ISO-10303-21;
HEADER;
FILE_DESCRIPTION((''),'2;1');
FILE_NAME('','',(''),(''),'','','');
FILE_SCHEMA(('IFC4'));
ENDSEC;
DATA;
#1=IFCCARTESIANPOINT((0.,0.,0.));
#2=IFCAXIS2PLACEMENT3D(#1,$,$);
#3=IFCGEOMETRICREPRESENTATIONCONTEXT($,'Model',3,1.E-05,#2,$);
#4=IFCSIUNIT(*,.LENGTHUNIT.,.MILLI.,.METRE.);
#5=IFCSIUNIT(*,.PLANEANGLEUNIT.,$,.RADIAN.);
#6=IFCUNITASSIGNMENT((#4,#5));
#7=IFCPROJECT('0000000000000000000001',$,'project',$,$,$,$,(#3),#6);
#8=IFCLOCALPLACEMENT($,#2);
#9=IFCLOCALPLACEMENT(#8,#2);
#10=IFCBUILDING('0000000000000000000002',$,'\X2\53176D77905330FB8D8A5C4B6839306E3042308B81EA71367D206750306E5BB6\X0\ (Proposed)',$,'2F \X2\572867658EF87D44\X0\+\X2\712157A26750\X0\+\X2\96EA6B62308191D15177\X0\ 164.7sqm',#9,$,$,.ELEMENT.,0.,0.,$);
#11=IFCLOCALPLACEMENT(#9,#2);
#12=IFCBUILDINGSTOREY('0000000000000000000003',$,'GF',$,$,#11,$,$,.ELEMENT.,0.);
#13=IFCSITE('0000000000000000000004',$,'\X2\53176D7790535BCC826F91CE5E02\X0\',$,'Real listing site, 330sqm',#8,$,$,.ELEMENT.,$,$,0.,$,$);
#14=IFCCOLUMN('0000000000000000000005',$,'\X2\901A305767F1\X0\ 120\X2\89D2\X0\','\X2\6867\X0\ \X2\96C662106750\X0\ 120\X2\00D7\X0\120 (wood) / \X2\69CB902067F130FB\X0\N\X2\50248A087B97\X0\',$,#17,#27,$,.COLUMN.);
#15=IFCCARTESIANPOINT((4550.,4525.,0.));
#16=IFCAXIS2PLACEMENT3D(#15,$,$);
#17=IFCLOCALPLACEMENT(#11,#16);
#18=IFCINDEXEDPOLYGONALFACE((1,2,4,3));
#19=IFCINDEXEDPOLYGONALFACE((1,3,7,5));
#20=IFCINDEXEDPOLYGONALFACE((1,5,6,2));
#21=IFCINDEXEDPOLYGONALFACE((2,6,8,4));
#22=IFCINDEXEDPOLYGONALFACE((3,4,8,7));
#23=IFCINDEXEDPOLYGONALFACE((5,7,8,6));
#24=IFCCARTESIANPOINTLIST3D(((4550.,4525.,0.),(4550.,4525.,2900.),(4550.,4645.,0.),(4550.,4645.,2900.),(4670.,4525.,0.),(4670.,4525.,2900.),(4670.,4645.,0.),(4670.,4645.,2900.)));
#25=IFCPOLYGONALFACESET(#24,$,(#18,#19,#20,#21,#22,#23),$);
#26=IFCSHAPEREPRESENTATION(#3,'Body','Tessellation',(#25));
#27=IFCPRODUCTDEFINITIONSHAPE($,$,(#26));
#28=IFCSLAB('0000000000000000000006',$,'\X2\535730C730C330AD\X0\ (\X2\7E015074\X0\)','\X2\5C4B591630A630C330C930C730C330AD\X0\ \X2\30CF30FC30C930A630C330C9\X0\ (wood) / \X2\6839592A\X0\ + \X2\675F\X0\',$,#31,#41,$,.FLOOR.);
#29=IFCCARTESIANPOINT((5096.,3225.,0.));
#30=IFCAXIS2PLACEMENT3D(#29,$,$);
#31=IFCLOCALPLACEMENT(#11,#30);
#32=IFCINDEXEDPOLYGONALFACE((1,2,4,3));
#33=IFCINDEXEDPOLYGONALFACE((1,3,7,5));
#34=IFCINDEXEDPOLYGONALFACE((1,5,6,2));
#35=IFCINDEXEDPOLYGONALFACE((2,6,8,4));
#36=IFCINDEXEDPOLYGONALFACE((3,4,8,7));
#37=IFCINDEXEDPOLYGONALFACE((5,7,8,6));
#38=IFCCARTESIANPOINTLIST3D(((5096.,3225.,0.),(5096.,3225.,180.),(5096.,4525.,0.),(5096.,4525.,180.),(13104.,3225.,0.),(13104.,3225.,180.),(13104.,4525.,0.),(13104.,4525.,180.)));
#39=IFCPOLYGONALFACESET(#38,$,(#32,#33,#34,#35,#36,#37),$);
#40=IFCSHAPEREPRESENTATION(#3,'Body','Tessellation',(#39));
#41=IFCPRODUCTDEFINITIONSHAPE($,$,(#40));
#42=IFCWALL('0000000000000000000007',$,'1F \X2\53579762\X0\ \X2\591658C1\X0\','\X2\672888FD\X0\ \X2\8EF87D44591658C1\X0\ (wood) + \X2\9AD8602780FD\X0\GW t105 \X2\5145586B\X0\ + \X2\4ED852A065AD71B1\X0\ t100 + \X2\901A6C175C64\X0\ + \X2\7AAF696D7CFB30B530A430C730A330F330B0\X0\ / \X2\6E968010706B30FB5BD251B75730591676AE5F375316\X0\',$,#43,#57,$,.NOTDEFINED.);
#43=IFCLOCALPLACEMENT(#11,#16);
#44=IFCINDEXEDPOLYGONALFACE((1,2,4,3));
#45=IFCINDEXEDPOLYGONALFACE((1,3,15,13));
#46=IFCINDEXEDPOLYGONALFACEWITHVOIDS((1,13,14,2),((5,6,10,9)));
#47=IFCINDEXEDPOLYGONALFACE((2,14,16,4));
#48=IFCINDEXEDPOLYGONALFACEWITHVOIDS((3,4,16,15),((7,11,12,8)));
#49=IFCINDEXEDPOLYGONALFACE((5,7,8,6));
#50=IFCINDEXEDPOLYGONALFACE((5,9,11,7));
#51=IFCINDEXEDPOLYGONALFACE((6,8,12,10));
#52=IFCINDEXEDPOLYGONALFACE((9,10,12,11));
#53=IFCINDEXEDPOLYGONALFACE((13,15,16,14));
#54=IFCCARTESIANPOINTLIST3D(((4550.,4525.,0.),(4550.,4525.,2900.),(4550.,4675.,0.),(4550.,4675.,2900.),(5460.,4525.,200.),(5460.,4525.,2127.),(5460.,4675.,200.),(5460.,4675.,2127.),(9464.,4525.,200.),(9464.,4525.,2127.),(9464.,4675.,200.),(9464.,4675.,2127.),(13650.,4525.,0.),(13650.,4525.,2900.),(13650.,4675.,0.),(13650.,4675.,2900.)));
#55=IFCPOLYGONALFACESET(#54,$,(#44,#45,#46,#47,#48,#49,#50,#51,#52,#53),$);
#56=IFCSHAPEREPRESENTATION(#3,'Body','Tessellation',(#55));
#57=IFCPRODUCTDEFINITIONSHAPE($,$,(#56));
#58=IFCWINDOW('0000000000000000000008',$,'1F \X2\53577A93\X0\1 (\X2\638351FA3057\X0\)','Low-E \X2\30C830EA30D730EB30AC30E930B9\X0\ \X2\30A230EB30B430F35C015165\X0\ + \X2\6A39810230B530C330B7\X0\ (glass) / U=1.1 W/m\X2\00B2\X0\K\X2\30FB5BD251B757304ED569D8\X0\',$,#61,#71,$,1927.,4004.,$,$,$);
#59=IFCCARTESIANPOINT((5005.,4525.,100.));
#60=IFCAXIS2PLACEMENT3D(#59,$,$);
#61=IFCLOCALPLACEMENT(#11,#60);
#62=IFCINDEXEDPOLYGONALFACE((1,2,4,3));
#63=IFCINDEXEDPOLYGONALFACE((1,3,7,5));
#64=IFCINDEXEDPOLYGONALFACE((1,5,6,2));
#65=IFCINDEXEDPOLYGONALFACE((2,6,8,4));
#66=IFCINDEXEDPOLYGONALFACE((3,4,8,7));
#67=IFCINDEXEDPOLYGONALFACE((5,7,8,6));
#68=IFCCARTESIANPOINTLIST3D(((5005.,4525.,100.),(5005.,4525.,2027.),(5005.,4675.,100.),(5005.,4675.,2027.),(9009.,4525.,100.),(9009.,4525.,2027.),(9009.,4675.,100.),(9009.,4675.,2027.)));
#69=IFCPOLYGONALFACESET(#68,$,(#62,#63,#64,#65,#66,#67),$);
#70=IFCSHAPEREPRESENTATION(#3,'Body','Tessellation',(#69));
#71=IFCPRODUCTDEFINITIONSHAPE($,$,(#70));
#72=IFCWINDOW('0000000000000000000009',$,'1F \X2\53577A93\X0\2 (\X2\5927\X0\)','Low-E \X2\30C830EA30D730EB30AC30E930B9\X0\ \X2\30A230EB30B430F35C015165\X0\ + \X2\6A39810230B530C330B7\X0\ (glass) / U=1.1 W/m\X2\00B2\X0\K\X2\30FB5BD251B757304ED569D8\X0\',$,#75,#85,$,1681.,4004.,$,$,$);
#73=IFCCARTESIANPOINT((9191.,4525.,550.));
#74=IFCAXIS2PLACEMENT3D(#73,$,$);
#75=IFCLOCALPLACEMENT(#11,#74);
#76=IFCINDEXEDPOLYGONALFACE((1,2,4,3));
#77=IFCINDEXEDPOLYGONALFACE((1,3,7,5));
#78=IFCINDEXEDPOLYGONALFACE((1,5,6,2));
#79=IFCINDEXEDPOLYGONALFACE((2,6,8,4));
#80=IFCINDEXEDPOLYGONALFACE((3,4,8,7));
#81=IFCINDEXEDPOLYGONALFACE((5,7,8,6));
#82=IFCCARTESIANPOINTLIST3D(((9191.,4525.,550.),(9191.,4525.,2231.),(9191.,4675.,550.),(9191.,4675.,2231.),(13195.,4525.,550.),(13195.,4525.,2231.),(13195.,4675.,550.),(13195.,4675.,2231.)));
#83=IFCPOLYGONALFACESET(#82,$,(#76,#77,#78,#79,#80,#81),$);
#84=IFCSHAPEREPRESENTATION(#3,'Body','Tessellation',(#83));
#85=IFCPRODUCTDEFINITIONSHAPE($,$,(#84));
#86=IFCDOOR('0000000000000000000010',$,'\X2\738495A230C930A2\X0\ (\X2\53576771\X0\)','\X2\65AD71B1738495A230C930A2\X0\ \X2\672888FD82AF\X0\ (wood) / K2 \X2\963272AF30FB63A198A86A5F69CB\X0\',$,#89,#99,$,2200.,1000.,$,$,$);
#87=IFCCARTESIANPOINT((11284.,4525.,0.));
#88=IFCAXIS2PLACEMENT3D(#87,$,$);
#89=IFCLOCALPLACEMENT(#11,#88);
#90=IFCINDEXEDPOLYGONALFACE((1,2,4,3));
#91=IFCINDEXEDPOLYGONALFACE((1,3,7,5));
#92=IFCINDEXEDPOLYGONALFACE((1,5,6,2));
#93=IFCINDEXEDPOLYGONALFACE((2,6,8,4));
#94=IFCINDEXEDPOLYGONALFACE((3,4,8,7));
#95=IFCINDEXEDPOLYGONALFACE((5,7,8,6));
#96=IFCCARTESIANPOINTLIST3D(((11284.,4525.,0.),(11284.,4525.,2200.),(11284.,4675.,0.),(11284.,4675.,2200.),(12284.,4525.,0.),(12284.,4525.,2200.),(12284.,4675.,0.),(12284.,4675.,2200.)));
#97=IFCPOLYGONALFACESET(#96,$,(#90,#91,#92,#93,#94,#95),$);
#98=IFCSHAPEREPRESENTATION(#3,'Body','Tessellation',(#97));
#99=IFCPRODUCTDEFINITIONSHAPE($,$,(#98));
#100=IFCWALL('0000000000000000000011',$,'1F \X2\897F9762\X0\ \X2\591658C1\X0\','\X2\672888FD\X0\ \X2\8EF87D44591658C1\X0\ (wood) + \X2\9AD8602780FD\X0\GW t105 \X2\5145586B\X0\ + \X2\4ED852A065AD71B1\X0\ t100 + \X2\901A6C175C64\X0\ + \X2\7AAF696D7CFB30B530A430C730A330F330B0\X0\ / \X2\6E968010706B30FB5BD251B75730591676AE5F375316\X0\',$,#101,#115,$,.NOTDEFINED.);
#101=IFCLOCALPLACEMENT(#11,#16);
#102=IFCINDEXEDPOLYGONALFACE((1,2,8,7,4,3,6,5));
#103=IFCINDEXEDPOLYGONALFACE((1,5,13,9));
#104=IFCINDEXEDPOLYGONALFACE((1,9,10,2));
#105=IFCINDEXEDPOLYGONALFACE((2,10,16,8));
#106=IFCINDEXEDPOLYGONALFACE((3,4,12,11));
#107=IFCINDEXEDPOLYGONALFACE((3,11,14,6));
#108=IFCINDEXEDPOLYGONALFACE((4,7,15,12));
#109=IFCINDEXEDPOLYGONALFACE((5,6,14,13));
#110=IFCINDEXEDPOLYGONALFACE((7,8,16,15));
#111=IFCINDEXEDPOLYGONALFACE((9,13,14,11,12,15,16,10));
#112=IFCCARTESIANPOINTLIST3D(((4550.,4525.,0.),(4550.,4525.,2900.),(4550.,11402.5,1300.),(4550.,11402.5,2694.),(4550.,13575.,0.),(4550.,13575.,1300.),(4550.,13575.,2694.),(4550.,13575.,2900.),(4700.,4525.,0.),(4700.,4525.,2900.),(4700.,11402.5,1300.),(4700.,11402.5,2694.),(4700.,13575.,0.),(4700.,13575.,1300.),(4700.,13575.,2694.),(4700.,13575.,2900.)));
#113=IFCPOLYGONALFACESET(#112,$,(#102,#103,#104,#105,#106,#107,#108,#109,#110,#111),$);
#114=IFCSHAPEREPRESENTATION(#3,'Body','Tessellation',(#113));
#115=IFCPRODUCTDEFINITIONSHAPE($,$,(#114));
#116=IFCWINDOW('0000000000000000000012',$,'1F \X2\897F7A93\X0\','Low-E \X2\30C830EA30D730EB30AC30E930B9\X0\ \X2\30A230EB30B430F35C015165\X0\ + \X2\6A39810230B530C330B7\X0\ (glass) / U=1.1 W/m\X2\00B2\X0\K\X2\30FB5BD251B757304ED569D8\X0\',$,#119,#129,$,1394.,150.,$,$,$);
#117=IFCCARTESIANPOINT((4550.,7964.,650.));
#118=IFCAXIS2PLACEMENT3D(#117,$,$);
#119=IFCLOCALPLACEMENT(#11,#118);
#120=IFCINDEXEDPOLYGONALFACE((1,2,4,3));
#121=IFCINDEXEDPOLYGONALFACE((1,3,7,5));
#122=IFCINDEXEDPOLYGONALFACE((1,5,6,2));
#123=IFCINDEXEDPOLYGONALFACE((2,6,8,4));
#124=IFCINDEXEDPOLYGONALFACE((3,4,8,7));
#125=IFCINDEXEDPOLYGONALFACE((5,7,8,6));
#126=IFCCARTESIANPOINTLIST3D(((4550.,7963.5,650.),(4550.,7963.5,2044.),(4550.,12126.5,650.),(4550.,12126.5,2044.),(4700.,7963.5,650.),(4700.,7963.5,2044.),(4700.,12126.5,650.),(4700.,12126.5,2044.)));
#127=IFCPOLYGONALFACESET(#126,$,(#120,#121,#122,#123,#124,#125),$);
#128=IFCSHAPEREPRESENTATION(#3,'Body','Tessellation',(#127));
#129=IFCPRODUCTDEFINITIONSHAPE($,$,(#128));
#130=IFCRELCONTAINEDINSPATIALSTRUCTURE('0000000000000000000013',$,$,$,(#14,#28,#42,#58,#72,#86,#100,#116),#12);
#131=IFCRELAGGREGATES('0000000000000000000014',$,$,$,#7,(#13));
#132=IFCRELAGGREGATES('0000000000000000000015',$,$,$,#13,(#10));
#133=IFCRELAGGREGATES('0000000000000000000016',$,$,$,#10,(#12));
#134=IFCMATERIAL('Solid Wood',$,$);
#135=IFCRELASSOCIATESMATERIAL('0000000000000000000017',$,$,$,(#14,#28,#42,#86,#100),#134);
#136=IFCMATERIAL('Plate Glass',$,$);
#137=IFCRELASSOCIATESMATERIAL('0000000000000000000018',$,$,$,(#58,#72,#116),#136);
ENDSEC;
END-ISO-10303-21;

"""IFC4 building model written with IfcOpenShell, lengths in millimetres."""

from ifc_helpers import new_model, si_unit, frame, frame_2d, origin, place, context, project, spatial, rectangle, extrude, material, element, fill, save


model = new_model("IFC4")

# Units and contexts
model_context = context("Model", 3, precision=1e-05, world=origin())
ifc_project = project(units=[si_unit("LENGTHUNIT", "METRE", prefix="MILLI"), si_unit("PLANEANGLEUNIT", "RADIAN")], contexts=[model_context])

# Site, building, storey
site_placement = place(None, origin())
site = spatial("IfcSite", under=ifc_project, at=site_placement, Name="北海道富良野市", ObjectType="Real listing site, 330sqm", CompositionType="ELEMENT", RefElevation=0.0)
building_placement = place(site_placement, origin())
building = spatial("IfcBuilding", under=site, at=building_placement, Name="北海道・越屋根のある自然素材の家 (Proposed)", ObjectType="2F 在来軸組+無垢材+雪止め金具 164.7sqm", CompositionType="ELEMENT", ElevationOfRefHeight=0.0, ElevationOfTerrain=0.0)
storey_placement = place(building_placement, origin())
storey = spatial("IfcBuildingStorey", under=building, at=storey_placement, Name="GF", CompositionType="ELEMENT", Elevation=0.0)

# Column
ifc_material_1 = material(Name="Solid Wood")
column_placement = place(storey_placement, frame((4550.0, 4525.0, 0.0)))
element("IfcColumn", 1, at=column_placement, inside=storey, material=ifc_material_1, Name="通し柱 120角", Description="桧 集成材 120×120 (wood) / 構造柱・N値計算", PredefinedType="COLUMN", context=model_context, shape_type="SweptSolid", body=[
    extrude(rectangle(XDim=120.0, YDim=120.0, at=frame_2d((60.0, 60.0))), frame((4550.0, 4525.0, 0.0)), (0.0, 0.0, 1.0), 2900.0),
])

# Slab
slab_1_placement = place(storey_placement, frame((5096.0, 3225.0, 0.0)))
element("IfcSlab", 2, at=slab_1_placement, inside=storey, material=ifc_material_1, Name="南デッキ (縁側)", Description="屋外ウッドデッキ ハードウッド (wood) / 根太 + 束", PredefinedType="FLOOR", context=model_context, shape_type="SweptSolid", body=[
    extrude(rectangle(XDim=8008.0, YDim=1300.0, at=frame_2d((4004.0, 650.0))), frame((5096.0, 3225.0, 0.0)), (0.0, 0.0, 1.0), 180.0),
])

# Wall, openings, windows, door
wall_1_placement = place(storey_placement, frame((4550.0, 4525.0, 0.0)))
wall_1 = element("IfcWall", 3, at=wall_1_placement, inside=storey, material=ifc_material_1, Name="1F 南面 外壁", Description="木製 軸組外壁 (wood) + 高性能GW t105 充填 + 付加断熱 t100 + 通気層 + 窯業系サイディング / 準耐火・寒冷地外皮強化", PredefinedType="NOTDEFINED", context=model_context, shape_type="SweptSolid", body=[
    extrude(rectangle(XDim=9100.0, YDim=150.0, at=frame_2d((4550.0, 75.0))), frame((4550.0, 4525.0, 0.0)), (0.0, 0.0, 1.0), 2900.0),
])
opening_1_placement = place(storey_placement, frame((5005.0, 4525.0, 100.0)))
opening_1 = element("IfcOpeningElement", 4, at=opening_1_placement, cuts=wall_1, PredefinedType="NOTDEFINED", context=model_context, shape_type="SweptSolid", body=[
    extrude(rectangle(XDim=4004.0, YDim=150.0, at=frame_2d((2002.0, 75.0))), frame((5005.0, 4525.0, 100.0)), (0.0, 0.0, 1.0), 1927.0),
])
opening_2_placement = place(storey_placement, frame((9191.0, 4525.0, 550.0)))
opening_2 = element("IfcOpeningElement", 5, at=opening_2_placement, cuts=wall_1, PredefinedType="NOTDEFINED", context=model_context, shape_type="SweptSolid", body=[
    extrude(rectangle(XDim=4004.0, YDim=150.0, at=frame_2d((2002.0, 75.0))), frame((9191.0, 4525.0, 550.0)), (0.0, 0.0, 1.0), 1681.0),
])
opening_3_placement = place(storey_placement, frame((11284.0, 4525.0, 0.0)))
opening_3 = element("IfcOpeningElement", 6, at=opening_3_placement, cuts=wall_1, PredefinedType="NOTDEFINED", context=model_context, shape_type="SweptSolid", body=[
    extrude(rectangle(XDim=1000.0, YDim=150.0, at=frame_2d((500.0, 75.0))), frame((11284.0, 4525.0, 0.0)), (0.0, 0.0, 1.0), 2200.0),
])
ifc_material_2 = material(Name="Plate Glass")
window_1_placement = place(storey_placement, frame((5005.0, 4525.0, 100.0)))
window_1 = element("IfcWindow", 7, at=window_1_placement, inside=storey, material=ifc_material_2, Name="1F 南窓1 (掃出し)", Description="Low-E トリプルガラス アルゴン封入 + 樹脂サッシ (glass) / U=1.1 W/m²K・寒冷地仕様", OverallHeight=1927.0, OverallWidth=4004.0, context=model_context, shape_type="SweptSolid", body=[
    extrude(rectangle(XDim=4004.0, YDim=150.0, at=frame_2d((2002.0, 75.0))), frame((5005.0, 4525.0, 100.0)), (0.0, 0.0, 1.0), 1927.0),
])
fill(opening_1, window_1)
window_2_placement = place(storey_placement, frame((9191.0, 4525.0, 550.0)))
window_2 = element("IfcWindow", 8, at=window_2_placement, inside=storey, material=ifc_material_2, Name="1F 南窓2 (大)", Description="Low-E トリプルガラス アルゴン封入 + 樹脂サッシ (glass) / U=1.1 W/m²K・寒冷地仕様", OverallHeight=1681.0, OverallWidth=4004.0, context=model_context, shape_type="SweptSolid", body=[
    extrude(rectangle(XDim=4004.0, YDim=150.0, at=frame_2d((2002.0, 75.0))), frame((9191.0, 4525.0, 550.0)), (0.0, 0.0, 1.0), 1681.0),
])
fill(opening_2, window_2)
door_placement = place(storey_placement, frame((11284.0, 4525.0, 0.0)))
door = element("IfcDoor", 9, at=door_placement, inside=storey, material=ifc_material_1, Name="玄関ドア (南東)", Description="断熱玄関ドア 木製芯 (wood) / K2 防犯・採風機構", OverallHeight=2200.0, OverallWidth=1000.0, context=model_context, shape_type="SweptSolid", body=[
    extrude(rectangle(XDim=1000.0, YDim=150.0, at=frame_2d((500.0, 75.0))), frame((11284.0, 4525.0, 0.0)), (0.0, 0.0, 1.0), 2200.0),
])
fill(opening_3, door)

# Wall, opening, window
wall_2_placement = place(storey_placement, frame((4550.0, 4525.0, 0.0)))
wall_2 = element("IfcWall", 10, at=wall_2_placement, inside=storey, material=ifc_material_1, Name="1F 西面 外壁", Description="木製 軸組外壁 (wood) + 高性能GW t105 充填 + 付加断熱 t100 + 通気層 + 窯業系サイディング / 準耐火・寒冷地外皮強化", PredefinedType="NOTDEFINED", context=model_context, shape_type="SweptSolid", body=[
    extrude(rectangle(XDim=150.0, YDim=9050.0, at=frame_2d((75.0, 4525.0))), frame((4550.0, 4525.0, 0.0)), (0.0, 0.0, 1.0), 2900.0),
])
opening_4_placement = place(storey_placement, frame((4550.0, 7964.0, 650.0)))
opening_4 = element("IfcOpeningElement", 11, at=opening_4_placement, cuts=wall_2, PredefinedType="NOTDEFINED", context=model_context, shape_type="SweptSolid", body=[
    extrude(rectangle(XDim=150.0, YDim=4163.0, at=frame_2d((75.0, 2081.0))), frame((4550.0, 7964.0, 650.0)), (0.0, 0.0, 1.0), 1394.0),
])
window_3_placement = place(storey_placement, frame((4550.0, 7964.0, 650.0)))
window_3 = element("IfcWindow", 12, at=window_3_placement, inside=storey, material=ifc_material_2, Name="1F 西窓", Description="Low-E トリプルガラス アルゴン封入 + 樹脂サッシ (glass) / U=1.1 W/m²K・寒冷地仕様", OverallHeight=1394.0, OverallWidth=150.0, context=model_context, shape_type="SweptSolid", body=[
    extrude(rectangle(XDim=150.0, YDim=4163.0, at=frame_2d((75.0, 2081.0))), frame((4550.0, 7964.0, 650.0)), (0.0, 0.0, 1.0), 1394.0),
])
fill(opening_4, window_3)

save(model, "model.ifc")
